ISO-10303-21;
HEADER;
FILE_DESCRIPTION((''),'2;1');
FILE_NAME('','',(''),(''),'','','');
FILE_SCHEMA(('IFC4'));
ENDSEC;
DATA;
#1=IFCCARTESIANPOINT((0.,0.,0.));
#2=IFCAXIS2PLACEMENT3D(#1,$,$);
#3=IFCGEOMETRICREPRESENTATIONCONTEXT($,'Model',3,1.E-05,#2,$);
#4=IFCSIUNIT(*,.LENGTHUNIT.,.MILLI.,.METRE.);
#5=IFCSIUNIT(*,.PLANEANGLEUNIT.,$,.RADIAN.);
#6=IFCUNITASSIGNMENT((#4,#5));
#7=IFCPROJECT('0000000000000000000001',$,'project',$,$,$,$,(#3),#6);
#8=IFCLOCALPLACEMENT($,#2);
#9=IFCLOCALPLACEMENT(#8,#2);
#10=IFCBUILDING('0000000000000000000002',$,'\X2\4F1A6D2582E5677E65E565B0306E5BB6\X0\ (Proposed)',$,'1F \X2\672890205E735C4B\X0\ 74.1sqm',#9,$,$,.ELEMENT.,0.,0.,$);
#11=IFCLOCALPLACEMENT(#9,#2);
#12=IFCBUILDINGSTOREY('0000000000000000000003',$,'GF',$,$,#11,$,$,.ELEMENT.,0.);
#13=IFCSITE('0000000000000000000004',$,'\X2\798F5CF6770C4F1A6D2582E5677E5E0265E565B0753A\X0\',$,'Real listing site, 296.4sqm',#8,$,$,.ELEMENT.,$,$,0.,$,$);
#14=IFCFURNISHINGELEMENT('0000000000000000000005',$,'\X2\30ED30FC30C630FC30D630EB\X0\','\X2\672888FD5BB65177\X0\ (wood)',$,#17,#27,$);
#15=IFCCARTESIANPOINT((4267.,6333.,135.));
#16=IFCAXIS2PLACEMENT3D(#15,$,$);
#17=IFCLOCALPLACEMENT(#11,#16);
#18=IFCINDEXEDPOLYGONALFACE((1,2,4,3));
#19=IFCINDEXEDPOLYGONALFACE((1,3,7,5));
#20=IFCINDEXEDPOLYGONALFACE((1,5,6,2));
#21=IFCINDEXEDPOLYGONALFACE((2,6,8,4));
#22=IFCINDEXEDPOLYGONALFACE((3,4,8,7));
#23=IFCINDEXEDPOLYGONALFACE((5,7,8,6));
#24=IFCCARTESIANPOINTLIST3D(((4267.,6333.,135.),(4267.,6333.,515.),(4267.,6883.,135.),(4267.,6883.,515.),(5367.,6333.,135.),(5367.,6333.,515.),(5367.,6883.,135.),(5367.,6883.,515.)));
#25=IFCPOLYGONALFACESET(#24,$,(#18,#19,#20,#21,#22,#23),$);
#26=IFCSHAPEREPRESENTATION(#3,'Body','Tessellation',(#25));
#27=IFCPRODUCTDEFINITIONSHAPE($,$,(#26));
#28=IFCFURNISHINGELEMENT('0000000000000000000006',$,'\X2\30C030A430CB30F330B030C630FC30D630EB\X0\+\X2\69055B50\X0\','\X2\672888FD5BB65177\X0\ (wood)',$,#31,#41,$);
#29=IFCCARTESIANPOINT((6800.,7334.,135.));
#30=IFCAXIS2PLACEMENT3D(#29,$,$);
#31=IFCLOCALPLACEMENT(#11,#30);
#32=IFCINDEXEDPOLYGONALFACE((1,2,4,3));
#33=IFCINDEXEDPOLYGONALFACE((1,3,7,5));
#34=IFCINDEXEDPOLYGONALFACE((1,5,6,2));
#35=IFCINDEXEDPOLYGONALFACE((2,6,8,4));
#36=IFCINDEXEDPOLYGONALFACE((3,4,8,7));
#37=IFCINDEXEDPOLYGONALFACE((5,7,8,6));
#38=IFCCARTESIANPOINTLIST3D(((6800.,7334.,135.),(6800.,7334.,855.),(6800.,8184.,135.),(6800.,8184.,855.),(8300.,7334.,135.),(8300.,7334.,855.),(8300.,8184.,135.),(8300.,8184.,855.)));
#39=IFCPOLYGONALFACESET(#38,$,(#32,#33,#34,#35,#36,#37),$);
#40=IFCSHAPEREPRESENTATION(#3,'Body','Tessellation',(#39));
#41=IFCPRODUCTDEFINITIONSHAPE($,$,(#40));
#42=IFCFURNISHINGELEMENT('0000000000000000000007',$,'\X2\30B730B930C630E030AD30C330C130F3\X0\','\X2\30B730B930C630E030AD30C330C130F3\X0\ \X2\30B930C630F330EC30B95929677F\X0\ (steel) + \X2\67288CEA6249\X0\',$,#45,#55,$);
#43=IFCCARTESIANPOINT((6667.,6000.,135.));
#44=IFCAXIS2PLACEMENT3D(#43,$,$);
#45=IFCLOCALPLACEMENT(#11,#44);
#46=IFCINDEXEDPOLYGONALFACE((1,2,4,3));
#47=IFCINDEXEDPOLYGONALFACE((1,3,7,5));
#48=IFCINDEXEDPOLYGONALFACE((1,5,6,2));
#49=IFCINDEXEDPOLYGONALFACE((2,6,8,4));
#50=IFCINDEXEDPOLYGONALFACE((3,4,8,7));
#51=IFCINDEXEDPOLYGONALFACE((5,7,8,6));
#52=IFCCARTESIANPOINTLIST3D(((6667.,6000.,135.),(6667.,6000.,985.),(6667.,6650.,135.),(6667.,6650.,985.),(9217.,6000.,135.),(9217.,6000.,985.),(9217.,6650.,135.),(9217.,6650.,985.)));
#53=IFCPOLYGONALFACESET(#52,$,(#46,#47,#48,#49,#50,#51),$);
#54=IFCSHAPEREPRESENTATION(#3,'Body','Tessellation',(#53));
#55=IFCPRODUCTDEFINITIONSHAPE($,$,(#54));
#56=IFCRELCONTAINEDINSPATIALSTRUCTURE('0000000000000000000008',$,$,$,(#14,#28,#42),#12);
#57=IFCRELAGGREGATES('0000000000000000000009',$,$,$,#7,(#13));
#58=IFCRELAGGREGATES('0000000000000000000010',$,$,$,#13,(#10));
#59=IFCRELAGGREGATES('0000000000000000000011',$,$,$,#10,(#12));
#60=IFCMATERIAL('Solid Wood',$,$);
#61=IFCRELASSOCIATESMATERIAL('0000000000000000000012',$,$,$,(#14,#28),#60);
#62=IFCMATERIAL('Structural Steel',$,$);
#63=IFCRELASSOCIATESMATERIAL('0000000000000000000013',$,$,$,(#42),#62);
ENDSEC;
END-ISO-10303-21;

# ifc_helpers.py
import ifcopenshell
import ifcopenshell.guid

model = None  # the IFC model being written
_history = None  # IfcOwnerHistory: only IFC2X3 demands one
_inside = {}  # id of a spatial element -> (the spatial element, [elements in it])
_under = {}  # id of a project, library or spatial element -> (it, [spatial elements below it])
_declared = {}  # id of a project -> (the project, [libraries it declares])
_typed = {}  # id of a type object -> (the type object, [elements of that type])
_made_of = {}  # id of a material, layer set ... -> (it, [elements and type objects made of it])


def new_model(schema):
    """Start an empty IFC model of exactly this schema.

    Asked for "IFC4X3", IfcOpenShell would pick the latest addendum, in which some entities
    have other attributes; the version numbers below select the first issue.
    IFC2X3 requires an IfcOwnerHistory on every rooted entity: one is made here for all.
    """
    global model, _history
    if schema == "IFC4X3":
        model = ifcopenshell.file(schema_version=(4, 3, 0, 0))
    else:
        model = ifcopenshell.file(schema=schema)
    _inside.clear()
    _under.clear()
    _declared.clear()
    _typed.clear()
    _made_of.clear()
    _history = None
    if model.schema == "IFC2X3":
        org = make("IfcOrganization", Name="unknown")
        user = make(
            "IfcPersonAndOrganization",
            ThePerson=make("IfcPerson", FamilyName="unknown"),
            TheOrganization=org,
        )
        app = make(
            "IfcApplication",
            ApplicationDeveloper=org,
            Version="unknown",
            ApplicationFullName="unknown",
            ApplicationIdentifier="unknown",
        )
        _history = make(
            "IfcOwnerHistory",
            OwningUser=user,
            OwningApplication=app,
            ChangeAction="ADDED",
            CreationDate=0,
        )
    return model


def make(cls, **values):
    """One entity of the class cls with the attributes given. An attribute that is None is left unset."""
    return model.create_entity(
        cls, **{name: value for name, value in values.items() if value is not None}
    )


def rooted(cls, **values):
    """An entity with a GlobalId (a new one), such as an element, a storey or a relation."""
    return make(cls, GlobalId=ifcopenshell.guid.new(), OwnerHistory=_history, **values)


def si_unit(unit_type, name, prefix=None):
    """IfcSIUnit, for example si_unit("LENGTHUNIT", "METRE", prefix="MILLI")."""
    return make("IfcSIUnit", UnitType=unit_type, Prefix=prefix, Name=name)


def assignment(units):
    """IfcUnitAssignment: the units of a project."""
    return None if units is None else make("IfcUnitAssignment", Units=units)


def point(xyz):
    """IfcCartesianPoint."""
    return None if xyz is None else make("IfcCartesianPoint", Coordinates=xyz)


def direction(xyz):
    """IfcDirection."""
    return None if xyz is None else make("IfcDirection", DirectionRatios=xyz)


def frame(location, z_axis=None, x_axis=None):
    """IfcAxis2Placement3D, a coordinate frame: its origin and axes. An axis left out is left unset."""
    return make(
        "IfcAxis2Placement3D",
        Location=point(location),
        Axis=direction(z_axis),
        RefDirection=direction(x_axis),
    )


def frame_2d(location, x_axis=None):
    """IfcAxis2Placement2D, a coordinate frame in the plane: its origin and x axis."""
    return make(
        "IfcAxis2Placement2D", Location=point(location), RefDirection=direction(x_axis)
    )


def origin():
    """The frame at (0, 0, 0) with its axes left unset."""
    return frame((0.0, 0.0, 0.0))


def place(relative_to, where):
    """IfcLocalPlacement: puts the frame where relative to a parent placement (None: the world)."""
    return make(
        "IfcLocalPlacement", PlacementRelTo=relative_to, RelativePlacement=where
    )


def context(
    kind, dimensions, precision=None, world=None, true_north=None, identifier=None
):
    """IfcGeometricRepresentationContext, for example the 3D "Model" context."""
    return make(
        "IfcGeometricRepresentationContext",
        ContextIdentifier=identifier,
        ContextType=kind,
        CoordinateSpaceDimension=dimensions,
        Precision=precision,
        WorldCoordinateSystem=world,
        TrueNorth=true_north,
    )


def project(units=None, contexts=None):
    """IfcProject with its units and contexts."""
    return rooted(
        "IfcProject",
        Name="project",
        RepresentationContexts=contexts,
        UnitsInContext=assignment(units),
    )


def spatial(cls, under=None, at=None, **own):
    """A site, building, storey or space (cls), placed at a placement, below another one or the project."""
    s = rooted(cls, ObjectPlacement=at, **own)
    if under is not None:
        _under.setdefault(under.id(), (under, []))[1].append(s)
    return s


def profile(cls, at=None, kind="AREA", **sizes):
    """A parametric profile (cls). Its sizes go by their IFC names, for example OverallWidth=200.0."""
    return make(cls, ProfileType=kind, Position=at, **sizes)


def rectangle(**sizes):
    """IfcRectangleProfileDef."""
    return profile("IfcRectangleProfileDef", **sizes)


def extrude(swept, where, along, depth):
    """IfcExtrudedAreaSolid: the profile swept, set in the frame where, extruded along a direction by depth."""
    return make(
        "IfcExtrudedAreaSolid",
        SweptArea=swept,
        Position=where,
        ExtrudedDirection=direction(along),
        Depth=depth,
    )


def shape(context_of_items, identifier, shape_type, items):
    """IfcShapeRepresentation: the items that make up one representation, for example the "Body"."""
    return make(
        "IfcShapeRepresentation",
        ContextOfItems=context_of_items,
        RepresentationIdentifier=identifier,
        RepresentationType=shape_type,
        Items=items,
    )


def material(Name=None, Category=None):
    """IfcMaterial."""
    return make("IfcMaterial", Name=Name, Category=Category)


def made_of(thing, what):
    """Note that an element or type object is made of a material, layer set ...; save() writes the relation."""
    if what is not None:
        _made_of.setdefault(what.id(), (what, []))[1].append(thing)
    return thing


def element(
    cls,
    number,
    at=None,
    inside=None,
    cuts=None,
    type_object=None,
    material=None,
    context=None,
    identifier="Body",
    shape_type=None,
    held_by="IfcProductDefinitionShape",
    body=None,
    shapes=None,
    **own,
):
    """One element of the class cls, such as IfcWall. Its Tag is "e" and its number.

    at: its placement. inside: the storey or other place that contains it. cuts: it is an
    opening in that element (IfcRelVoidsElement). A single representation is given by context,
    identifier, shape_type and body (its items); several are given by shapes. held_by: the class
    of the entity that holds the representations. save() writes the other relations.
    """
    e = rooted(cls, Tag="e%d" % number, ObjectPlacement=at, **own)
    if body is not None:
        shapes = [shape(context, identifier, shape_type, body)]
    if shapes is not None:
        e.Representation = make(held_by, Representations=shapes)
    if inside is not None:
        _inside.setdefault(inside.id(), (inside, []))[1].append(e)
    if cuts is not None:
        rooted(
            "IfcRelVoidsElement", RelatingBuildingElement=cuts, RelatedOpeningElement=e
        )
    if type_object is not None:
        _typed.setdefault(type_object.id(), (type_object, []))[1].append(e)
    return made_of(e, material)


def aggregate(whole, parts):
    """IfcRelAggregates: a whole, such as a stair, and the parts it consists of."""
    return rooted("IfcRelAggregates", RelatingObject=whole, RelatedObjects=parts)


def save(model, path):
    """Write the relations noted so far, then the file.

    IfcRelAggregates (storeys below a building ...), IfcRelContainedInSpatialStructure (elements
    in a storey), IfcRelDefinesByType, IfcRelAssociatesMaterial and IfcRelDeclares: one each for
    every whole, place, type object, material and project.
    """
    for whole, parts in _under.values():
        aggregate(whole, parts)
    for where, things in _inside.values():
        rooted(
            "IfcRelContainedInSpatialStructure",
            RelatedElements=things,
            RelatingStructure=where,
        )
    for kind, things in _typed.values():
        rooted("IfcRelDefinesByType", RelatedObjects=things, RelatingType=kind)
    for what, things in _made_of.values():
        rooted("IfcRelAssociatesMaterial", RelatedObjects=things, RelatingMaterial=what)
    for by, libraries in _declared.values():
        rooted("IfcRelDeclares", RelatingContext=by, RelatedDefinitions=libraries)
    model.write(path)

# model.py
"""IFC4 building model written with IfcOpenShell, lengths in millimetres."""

from ifc_helpers import new_model, si_unit, frame, frame_2d, origin, place, context, project, spatial, rectangle, extrude, material, element, save


model = new_model("IFC4")

# Units and contexts
model_context = context("Model", 3, precision=1e-05, world=origin())
ifc_project = project(units=[si_unit("LENGTHUNIT", "METRE", prefix="MILLI"), si_unit("PLANEANGLEUNIT", "RADIAN")], contexts=[model_context])

# Site, building, storey
site_placement = place(None, origin())
site = spatial("IfcSite", under=ifc_project, at=site_placement, Name="福島県会津若松市日新町", ObjectType="Real listing site, 296.4sqm", CompositionType="ELEMENT", RefElevation=0.0)
building_placement = place(site_placement, origin())
building = spatial("IfcBuilding", under=site, at=building_placement, Name="会津若松日新の家 (Proposed)", ObjectType="1F 木造平屋 74.1sqm", CompositionType="ELEMENT", ElevationOfRefHeight=0.0, ElevationOfTerrain=0.0)
storey_placement = place(building_placement, origin())
storey = spatial("IfcBuildingStorey", under=building, at=storey_placement, Name="GF", CompositionType="ELEMENT", Elevation=0.0)

# Shared definitions
ifc_material_1 = material(Name="Solid Wood")

# Shared definitions
ifc_material_2 = material(Name="Structural Steel")

# Furnishing elements
furnishing_1_placement = place(storey_placement, frame((4267.0, 6333.0, 135.0)))
element("IfcFurnishingElement", 1, at=furnishing_1_placement, inside=storey, material=ifc_material_1, Name="ローテーブル", Description="木製家具 (wood)", context=model_context, shape_type="SweptSolid", body=[
    extrude(rectangle(XDim=1100.0, YDim=550.0, at=frame_2d((550.0, 275.0))), frame((4267.0, 6333.0, 135.0)), (0.0, 0.0, 1.0), 380.0),
])
furnishing_2_placement = place(storey_placement, frame((6800.0, 7334.0, 135.0)))
element("IfcFurnishingElement", 2, at=furnishing_2_placement, inside=storey, material=ifc_material_1, Name="ダイニングテーブル+椅子", Description="木製家具 (wood)", context=model_context, shape_type="SweptSolid", body=[
    extrude(rectangle(XDim=1500.0, YDim=850.0, at=frame_2d((750.0, 425.0))), frame((6800.0, 7334.0, 135.0)), (0.0, 0.0, 1.0), 720.0),
])
furnishing_3_placement = place(storey_placement, frame((6667.0, 6000.0, 135.0)))
element("IfcFurnishingElement", 3, at=furnishing_3_placement, inside=storey, material=ifc_material_2, Name="システムキッチン", Description="システムキッチン ステンレス天板 (steel) + 木質扉", context=model_context, shape_type="SweptSolid", body=[
    extrude(rectangle(XDim=2550.0, YDim=650.0, at=frame_2d((1275.0, 325.0))), frame((6667.0, 6000.0, 135.0)), (0.0, 0.0, 1.0), 850.0),
])

save(model, "model.ifc")
